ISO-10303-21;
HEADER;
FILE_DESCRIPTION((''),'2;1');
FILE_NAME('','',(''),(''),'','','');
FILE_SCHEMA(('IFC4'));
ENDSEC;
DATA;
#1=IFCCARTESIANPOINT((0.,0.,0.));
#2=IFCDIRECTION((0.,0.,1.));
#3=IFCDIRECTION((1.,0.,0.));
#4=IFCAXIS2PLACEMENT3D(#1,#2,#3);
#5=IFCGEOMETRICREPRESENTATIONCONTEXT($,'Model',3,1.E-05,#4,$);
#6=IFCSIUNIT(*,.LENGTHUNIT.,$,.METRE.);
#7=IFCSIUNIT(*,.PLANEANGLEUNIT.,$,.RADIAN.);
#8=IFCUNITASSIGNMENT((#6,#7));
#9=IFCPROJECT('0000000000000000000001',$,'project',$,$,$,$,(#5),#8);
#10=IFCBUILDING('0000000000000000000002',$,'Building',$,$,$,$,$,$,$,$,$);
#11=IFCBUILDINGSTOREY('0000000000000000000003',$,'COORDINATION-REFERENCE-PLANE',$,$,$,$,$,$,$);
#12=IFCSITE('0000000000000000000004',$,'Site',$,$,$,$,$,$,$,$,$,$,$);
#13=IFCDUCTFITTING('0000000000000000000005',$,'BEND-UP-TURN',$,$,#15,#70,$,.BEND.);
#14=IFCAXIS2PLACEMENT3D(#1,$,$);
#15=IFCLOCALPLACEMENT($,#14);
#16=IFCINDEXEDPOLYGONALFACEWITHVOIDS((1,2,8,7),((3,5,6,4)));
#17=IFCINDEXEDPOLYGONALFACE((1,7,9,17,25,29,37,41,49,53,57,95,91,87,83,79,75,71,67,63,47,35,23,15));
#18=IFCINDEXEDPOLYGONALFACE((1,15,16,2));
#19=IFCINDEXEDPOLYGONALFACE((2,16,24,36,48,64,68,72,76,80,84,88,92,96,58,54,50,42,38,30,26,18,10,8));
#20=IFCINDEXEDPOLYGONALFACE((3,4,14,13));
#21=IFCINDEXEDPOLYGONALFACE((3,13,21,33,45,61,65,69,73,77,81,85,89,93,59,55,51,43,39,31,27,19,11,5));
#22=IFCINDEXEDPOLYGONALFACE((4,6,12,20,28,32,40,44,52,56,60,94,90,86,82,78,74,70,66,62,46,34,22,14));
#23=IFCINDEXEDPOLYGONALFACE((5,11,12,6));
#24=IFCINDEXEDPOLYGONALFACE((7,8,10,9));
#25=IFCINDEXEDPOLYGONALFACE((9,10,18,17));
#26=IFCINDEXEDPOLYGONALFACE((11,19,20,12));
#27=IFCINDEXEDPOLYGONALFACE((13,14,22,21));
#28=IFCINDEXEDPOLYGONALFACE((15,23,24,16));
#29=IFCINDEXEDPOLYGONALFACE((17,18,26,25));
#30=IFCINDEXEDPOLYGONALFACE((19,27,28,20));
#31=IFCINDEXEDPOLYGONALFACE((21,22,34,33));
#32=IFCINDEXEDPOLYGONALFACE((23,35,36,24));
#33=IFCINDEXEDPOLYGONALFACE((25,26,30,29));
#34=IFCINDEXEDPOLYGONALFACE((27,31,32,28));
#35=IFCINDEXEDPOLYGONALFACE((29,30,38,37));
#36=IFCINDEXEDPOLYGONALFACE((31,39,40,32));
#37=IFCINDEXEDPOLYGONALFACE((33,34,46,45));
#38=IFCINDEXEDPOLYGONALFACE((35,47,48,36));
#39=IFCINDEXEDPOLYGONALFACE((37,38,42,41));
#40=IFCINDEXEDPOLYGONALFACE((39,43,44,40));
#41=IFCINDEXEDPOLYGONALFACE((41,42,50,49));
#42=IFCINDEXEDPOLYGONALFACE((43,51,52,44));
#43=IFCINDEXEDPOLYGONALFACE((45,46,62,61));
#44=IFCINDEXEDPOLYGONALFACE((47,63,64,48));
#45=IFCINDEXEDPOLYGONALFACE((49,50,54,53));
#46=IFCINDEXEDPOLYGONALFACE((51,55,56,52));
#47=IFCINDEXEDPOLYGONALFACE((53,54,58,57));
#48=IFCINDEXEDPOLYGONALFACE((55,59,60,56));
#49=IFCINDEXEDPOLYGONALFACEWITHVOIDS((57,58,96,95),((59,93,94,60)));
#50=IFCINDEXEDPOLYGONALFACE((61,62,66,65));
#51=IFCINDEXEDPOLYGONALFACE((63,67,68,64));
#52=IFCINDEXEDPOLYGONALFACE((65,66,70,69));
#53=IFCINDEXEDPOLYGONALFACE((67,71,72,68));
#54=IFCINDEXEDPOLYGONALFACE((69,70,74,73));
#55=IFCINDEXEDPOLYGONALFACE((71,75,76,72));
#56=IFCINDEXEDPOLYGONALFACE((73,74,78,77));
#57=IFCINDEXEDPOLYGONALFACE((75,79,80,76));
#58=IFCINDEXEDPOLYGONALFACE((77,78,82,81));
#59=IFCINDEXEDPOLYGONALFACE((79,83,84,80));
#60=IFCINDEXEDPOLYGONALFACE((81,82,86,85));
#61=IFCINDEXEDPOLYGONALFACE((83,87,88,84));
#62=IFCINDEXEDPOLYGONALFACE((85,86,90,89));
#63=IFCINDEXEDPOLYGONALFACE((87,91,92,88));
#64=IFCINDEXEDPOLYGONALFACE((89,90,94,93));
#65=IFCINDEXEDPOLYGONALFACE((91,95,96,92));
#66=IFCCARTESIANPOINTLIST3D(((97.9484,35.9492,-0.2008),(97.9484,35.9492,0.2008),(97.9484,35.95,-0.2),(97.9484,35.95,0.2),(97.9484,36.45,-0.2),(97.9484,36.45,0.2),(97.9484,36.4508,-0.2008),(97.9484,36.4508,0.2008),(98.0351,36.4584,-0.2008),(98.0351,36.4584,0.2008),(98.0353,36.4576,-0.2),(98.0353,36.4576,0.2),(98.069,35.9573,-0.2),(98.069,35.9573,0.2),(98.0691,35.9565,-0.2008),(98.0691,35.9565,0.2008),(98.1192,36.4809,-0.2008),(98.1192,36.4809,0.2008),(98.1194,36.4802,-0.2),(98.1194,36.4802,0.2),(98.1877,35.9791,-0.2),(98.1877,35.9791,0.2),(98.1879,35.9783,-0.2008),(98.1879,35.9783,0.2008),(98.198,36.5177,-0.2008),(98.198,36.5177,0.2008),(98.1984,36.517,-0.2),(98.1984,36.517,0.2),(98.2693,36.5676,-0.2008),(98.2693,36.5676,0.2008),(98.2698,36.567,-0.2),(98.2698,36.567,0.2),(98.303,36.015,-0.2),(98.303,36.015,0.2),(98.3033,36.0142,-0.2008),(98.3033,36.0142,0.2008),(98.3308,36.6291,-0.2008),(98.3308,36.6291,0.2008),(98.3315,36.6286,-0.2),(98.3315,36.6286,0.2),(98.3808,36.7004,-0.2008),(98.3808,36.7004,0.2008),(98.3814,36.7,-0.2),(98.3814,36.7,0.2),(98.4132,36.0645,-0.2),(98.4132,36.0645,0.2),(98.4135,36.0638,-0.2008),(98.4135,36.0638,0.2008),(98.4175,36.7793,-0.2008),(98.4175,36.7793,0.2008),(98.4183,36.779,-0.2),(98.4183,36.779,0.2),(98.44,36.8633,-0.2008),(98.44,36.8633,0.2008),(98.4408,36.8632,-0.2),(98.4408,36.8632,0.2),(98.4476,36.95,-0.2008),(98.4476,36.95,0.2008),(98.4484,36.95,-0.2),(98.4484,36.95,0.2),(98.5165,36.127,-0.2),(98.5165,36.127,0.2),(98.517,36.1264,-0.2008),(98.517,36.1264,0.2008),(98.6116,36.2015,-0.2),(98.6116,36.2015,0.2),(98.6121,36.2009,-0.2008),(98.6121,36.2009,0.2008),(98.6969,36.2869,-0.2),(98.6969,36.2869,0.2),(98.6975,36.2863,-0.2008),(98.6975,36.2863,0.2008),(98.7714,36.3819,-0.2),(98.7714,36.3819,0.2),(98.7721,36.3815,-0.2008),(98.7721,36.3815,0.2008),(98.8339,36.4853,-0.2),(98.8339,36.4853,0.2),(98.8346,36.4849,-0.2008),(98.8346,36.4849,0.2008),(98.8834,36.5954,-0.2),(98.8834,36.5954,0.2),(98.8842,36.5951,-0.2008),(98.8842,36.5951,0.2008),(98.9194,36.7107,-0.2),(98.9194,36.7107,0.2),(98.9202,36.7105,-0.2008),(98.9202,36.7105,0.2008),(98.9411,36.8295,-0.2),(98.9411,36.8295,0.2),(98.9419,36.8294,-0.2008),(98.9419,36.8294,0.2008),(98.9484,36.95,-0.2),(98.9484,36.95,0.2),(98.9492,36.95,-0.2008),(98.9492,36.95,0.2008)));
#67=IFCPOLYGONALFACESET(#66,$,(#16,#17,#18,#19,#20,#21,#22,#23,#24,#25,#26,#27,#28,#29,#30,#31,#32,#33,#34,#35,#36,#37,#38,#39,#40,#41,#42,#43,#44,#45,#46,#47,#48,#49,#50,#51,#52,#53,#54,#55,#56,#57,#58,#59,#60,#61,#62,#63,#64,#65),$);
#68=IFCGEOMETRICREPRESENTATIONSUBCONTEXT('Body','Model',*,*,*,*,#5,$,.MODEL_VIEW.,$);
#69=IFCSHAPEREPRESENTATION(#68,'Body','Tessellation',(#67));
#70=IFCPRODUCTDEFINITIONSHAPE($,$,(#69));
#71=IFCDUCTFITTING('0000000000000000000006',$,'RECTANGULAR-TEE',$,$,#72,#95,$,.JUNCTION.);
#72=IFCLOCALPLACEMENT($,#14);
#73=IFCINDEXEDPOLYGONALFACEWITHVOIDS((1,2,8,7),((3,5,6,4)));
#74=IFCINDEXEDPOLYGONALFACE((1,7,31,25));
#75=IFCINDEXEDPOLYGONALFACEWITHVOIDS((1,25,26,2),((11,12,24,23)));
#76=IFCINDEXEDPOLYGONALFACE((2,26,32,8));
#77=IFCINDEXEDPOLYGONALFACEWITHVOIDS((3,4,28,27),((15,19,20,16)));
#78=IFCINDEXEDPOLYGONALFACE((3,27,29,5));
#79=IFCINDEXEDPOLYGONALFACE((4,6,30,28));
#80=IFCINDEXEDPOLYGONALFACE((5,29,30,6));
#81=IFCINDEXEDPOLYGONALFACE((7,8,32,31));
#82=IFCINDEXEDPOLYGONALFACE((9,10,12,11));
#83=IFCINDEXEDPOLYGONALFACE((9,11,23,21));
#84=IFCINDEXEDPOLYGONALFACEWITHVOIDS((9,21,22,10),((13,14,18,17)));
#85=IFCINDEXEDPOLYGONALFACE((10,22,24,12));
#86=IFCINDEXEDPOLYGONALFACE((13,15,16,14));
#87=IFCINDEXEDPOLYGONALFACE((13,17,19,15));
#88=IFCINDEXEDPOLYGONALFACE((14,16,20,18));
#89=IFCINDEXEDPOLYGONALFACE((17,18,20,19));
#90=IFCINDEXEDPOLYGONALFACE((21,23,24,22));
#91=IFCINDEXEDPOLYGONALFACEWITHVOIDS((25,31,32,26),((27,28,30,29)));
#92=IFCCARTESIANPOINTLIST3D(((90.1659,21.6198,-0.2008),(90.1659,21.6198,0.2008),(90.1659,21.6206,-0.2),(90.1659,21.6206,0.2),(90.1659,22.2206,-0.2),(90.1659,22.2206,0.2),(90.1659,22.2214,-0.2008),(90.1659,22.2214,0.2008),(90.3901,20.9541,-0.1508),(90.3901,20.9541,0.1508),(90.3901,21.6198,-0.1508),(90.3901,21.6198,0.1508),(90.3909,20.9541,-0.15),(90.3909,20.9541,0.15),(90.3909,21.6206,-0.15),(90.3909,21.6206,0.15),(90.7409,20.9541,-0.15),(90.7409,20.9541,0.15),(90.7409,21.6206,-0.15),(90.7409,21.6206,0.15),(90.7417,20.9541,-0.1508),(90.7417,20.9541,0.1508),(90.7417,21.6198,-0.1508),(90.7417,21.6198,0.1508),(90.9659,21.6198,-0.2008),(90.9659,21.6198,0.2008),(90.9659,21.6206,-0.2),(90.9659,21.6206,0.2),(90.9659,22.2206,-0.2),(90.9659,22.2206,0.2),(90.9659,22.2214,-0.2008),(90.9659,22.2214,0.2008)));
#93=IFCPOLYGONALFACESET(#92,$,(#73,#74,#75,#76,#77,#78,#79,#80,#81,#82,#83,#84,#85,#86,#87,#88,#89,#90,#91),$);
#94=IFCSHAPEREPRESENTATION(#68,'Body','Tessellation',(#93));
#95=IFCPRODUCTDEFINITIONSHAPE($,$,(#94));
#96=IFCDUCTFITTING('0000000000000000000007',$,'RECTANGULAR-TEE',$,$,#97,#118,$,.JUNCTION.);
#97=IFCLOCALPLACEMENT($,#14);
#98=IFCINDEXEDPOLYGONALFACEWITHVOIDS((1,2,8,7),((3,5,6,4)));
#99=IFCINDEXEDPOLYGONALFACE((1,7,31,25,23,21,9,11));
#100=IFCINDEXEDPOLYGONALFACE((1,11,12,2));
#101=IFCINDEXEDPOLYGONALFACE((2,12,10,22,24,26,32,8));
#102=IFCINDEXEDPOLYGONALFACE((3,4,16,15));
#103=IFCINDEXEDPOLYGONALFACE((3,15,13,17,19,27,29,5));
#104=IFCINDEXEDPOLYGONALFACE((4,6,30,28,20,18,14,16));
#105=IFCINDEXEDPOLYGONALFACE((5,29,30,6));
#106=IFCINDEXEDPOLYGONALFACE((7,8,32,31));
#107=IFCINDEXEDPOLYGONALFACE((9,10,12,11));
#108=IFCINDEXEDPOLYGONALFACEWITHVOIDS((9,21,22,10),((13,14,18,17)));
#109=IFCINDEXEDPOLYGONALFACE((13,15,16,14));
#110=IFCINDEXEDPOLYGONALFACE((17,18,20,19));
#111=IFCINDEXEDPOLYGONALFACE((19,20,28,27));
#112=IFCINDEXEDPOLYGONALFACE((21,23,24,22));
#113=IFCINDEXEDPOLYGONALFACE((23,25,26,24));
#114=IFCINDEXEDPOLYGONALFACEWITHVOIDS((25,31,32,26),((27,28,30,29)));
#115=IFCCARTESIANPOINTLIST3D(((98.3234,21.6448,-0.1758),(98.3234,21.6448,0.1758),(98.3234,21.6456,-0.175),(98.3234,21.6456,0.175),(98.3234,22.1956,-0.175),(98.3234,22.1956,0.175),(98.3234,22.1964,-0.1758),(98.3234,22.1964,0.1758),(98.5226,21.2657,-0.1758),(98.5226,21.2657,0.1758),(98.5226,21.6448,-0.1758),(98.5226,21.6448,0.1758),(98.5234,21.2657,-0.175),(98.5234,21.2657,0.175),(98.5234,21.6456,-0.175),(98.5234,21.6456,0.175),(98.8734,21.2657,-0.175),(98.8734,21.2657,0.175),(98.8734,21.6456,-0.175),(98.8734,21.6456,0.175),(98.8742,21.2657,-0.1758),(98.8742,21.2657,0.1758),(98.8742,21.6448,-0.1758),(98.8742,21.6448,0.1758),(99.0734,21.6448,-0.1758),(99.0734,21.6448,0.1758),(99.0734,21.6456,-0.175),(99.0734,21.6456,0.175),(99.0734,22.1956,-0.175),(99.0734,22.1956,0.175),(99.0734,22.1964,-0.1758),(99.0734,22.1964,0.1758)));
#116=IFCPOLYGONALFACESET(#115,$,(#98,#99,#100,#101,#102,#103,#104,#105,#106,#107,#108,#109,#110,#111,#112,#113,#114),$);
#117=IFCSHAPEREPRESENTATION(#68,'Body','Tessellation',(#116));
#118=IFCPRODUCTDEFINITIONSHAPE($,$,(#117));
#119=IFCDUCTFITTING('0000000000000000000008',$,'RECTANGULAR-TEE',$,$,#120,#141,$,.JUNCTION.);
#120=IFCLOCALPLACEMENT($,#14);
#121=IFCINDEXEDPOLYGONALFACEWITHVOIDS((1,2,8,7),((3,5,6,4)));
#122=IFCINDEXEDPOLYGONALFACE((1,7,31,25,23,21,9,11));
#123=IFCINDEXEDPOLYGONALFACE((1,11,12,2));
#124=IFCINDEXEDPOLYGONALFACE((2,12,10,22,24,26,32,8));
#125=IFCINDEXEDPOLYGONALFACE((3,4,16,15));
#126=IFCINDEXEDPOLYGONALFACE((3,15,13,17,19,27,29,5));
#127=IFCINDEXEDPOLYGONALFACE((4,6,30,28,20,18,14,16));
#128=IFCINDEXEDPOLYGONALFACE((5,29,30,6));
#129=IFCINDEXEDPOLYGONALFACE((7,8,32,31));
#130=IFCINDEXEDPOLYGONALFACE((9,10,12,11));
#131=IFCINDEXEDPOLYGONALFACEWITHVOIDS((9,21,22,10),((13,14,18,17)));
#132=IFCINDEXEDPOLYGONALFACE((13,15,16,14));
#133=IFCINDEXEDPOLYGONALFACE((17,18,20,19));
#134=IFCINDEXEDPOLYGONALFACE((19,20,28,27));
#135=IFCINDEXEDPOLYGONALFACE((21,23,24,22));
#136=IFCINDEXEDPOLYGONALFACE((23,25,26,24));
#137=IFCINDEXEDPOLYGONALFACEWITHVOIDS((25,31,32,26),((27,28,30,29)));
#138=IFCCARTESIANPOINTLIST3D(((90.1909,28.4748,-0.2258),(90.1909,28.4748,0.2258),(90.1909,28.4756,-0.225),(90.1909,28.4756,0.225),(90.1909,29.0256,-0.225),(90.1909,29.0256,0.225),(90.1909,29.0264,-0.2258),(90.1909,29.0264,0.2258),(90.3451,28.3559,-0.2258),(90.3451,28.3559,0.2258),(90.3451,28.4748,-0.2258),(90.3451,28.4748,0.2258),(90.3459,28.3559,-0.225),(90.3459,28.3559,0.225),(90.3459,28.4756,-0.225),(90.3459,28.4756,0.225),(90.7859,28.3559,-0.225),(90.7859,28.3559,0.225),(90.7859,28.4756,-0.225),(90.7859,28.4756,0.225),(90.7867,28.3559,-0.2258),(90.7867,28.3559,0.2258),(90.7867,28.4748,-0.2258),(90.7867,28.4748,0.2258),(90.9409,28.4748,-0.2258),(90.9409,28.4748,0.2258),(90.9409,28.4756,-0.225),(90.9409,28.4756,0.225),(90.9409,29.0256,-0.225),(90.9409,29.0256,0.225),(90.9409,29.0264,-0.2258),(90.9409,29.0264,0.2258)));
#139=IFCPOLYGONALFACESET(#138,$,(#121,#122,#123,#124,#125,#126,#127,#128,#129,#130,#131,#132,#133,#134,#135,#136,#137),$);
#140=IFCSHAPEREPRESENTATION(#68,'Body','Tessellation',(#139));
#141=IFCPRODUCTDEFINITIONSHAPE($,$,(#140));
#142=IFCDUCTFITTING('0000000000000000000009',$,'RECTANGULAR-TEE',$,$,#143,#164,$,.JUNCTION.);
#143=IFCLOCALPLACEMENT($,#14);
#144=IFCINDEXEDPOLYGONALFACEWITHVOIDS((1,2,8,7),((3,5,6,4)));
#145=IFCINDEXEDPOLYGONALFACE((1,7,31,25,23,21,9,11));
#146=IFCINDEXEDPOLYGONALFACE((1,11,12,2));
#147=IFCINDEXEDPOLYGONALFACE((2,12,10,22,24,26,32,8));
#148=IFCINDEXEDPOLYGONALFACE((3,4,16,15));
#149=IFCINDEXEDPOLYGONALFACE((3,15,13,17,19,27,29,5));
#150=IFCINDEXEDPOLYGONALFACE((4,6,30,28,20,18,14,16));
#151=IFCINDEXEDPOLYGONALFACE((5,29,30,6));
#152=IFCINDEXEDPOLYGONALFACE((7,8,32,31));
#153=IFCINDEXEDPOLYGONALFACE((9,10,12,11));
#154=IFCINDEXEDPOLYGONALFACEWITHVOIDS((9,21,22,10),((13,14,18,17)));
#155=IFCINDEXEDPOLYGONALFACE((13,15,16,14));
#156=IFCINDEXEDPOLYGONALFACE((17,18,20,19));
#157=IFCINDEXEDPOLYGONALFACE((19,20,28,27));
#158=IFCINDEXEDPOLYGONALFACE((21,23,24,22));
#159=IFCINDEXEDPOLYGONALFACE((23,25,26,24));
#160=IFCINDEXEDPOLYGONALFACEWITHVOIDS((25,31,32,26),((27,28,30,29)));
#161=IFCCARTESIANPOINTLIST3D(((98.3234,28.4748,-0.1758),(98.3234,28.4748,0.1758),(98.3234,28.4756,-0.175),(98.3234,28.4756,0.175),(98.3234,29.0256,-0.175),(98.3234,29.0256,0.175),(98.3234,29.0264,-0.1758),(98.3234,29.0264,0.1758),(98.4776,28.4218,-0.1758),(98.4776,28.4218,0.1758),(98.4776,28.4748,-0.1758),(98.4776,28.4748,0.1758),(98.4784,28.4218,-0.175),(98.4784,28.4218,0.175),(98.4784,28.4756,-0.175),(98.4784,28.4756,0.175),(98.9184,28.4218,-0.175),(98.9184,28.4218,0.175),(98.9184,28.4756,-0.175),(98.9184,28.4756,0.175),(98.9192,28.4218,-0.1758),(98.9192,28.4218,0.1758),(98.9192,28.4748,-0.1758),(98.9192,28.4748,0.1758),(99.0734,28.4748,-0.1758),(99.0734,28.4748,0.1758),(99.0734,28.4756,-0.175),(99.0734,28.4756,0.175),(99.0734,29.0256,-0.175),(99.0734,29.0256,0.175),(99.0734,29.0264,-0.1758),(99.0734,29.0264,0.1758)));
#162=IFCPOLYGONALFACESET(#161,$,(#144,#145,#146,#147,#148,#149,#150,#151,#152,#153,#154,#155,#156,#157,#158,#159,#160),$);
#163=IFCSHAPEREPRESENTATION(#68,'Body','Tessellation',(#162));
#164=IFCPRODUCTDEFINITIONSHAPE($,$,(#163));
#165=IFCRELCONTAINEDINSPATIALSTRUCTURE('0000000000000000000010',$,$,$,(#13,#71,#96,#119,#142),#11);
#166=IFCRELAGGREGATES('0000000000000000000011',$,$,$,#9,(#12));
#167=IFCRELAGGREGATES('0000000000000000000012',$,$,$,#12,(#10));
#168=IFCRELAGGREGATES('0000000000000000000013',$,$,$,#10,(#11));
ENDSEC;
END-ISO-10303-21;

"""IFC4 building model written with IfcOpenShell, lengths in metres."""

from ifc_helpers import new_model, entity, si_unit, frame, origin_with_axes, place, context, subcontext, project, spatial, rectangle, extrude, boolean, element, save


model = new_model("IFC4")

# Units and contexts
model_context = context("Model", 3, precision=1e-05, world=origin_with_axes())
body_context = subcontext(model_context, "Body", "Model", "MODEL_VIEW")
ifc_project = project(units=[si_unit("LENGTHUNIT", "METRE"), si_unit("PLANEANGLEUNIT", "RADIAN")], contexts=[model_context])

# Site, building, storey
site = spatial("IfcSite", under=ifc_project, Name="Site")
building = spatial("IfcBuilding", under=site, Name="Building")
storey = spatial("IfcBuildingStorey", under=building, Name="COORDINATION-REFERENCE-PLANE")

# Duct fittings
duct_fitting_1_placement = place(None, frame((97.9484, 36.95, 0.0), z_axis=(0.0, 0.0, 1.0), x_axis=(0.0, -1.0, 0.0)))
cartesian_point_1 = entity("IfcCartesianPoint", [0.0, 0.0, 0.0])
element("IfcDuctFitting", 1, at=duct_fitting_1_placement, inside=storey, Name="BEND-UP-TURN", PredefinedType="BEND", context=body_context, shape_type="SweptSolid", body=[
    entity("IfcRevolvedAreaSolid", entity("IfcRectangleHollowProfileDef", "AREA", None, entity("IfcAxis2Placement2D", entity("IfcCartesianPoint", [0.75, 0.0])), 0.5016, 0.4016, 0.0008), entity("IfcAxis2Placement3D", cartesian_point_1, entity("IfcDirection", [0.0, -1.0, 0.0]), entity("IfcDirection", [1.0, 0.0, 0.0])), entity("IfcAxis1Placement", cartesian_point_1, entity("IfcDirection", [0.0, 1.0, 0.0])), 1.570796),
])
duct_fitting_2_placement = place(None, frame((90.5659, 21.9206, 0.0), z_axis=(1.0, 0.0, 0.0), x_axis=(0.0, -1.0, 0.0)))
solid_1 = boolean("UNION", extrude(rectangle(XDim=0.6, YDim=0.4), frame((0.0, 0.0, -0.4), z_axis=(0.0, 0.0, 1.0), x_axis=(1.0, 0.0, 0.0)), (0.0, 0.0, 1.0), 0.8), extrude(rectangle(XDim=0.35, YDim=0.3), frame((0.0, 0.0, 0.0), z_axis=(1.0, 0.0, 0.0), x_axis=(0.0, 0.0, -1.0)), (0.0, 0.0, 1.0), 0.9665))
element("IfcDuctFitting", 2, at=duct_fitting_2_placement, inside=storey, Name="RECTANGULAR-TEE", PredefinedType="JUNCTION", context=body_context, shape_type="CSG", body=[
    boolean("DIFFERENCE", boolean("UNION", extrude(rectangle(XDim=0.6016, YDim=0.4016), frame((0.0, 0.0, -0.4), z_axis=(0.0, 0.0, 1.0), x_axis=(1.0, 0.0, 0.0)), (0.0, 0.0, 1.0), 0.8), extrude(rectangle(XDim=0.3516, YDim=0.3016), frame((0.0, 0.0, 0.0), z_axis=(1.0, 0.0, 0.0), x_axis=(0.0, 0.0, -1.0)), (0.0, 0.0, 1.0), 0.9665)), solid_1),
])
duct_fitting_3_placement = place(None, frame((98.6984, 21.9206, 0.0), z_axis=(1.0, 0.0, 0.0), x_axis=(0.0, -1.0, 0.0)))
solid_2 = boolean("UNION", extrude(rectangle(XDim=0.55, YDim=0.35), frame((0.0, 0.0, -0.375), z_axis=(0.0, 0.0, 1.0), x_axis=(1.0, 0.0, 0.0)), (0.0, 0.0, 1.0), 0.75), extrude(rectangle(XDim=0.35, YDim=0.35), frame((0.0, 0.0, 0.0), z_axis=(1.0, 0.0, 0.0), x_axis=(0.0, 0.0, -1.0)), (0.0, 0.0, 1.0), 0.6549))
element("IfcDuctFitting", 3, at=duct_fitting_3_placement, inside=storey, Name="RECTANGULAR-TEE", PredefinedType="JUNCTION", context=body_context, shape_type="CSG", body=[
    boolean("DIFFERENCE", boolean("UNION", extrude(rectangle(XDim=0.5516, YDim=0.3516), frame((0.0, 0.0, -0.375), z_axis=(0.0, 0.0, 1.0), x_axis=(1.0, 0.0, 0.0)), (0.0, 0.0, 1.0), 0.75), extrude(rectangle(XDim=0.3516, YDim=0.3516), frame((0.0, 0.0, 0.0), z_axis=(1.0, 0.0, 0.0), x_axis=(0.0, 0.0, -1.0)), (0.0, 0.0, 1.0), 0.6549)), solid_2),
])
duct_fitting_4_placement = place(None, frame((90.5659, 28.7506, 0.0), z_axis=(1.0, 0.0, 0.0), x_axis=(0.0, -1.0, 0.0)))
solid_3 = boolean("UNION", extrude(rectangle(XDim=0.55, YDim=0.45), frame((0.0, 0.0, -0.375), z_axis=(0.0, 0.0, 1.0), x_axis=(1.0, 0.0, 0.0)), (0.0, 0.0, 1.0), 0.75), extrude(rectangle(XDim=0.44, YDim=0.45), frame((0.0, 0.0, 0.0), z_axis=(1.0, 0.0, 0.0), x_axis=(0.0, 0.0, -1.0)), (0.0, 0.0, 1.0), 0.3947))
element("IfcDuctFitting", 4, at=duct_fitting_4_placement, inside=storey, Name="RECTANGULAR-TEE", PredefinedType="JUNCTION", context=body_context, shape_type="CSG", body=[
    boolean("DIFFERENCE", boolean("UNION", extrude(rectangle(XDim=0.5516, YDim=0.4516), frame((0.0, 0.0, -0.375), z_axis=(0.0, 0.0, 1.0), x_axis=(1.0, 0.0, 0.0)), (0.0, 0.0, 1.0), 0.75), extrude(rectangle(XDim=0.4416, YDim=0.4516), frame((0.0, 0.0, 0.0), z_axis=(1.0, 0.0, 0.0), x_axis=(0.0, 0.0, -1.0)), (0.0, 0.0, 1.0), 0.3947)), solid_3),
])
duct_fitting_5_placement = place(None, frame((98.6984, 28.7506, 0.0), z_axis=(1.0, 0.0, 0.0), x_axis=(0.0, -1.0, 0.0)))
solid_4 = boolean("UNION", extrude(rectangle(XDim=0.55, YDim=0.35), frame((0.0, 0.0, -0.375), z_axis=(0.0, 0.0, 1.0), x_axis=(1.0, 0.0, 0.0)), (0.0, 0.0, 1.0), 0.75), extrude(rectangle(XDim=0.44, YDim=0.35), frame((0.0, 0.0, 0.0), z_axis=(1.0, 0.0, 0.0), x_axis=(0.0, 0.0, -1.0)), (0.0, 0.0, 1.0), 0.3288))
element("IfcDuctFitting", 5, at=duct_fitting_5_placement, inside=storey, Name="RECTANGULAR-TEE", PredefinedType="JUNCTION", context=body_context, shape_type="CSG", body=[
    boolean("DIFFERENCE", boolean("UNION", extrude(rectangle(XDim=0.5516, YDim=0.3516), frame((0.0, 0.0, -0.375), z_axis=(0.0, 0.0, 1.0), x_axis=(1.0, 0.0, 0.0)), (0.0, 0.0, 1.0), 0.75), extrude(rectangle(XDim=0.4416, YDim=0.3516), frame((0.0, 0.0, 0.0), z_axis=(1.0, 0.0, 0.0), x_axis=(0.0, 0.0, -1.0)), (0.0, 0.0, 1.0), 0.3288)), solid_4),
])

save(model, "model.ifc")
